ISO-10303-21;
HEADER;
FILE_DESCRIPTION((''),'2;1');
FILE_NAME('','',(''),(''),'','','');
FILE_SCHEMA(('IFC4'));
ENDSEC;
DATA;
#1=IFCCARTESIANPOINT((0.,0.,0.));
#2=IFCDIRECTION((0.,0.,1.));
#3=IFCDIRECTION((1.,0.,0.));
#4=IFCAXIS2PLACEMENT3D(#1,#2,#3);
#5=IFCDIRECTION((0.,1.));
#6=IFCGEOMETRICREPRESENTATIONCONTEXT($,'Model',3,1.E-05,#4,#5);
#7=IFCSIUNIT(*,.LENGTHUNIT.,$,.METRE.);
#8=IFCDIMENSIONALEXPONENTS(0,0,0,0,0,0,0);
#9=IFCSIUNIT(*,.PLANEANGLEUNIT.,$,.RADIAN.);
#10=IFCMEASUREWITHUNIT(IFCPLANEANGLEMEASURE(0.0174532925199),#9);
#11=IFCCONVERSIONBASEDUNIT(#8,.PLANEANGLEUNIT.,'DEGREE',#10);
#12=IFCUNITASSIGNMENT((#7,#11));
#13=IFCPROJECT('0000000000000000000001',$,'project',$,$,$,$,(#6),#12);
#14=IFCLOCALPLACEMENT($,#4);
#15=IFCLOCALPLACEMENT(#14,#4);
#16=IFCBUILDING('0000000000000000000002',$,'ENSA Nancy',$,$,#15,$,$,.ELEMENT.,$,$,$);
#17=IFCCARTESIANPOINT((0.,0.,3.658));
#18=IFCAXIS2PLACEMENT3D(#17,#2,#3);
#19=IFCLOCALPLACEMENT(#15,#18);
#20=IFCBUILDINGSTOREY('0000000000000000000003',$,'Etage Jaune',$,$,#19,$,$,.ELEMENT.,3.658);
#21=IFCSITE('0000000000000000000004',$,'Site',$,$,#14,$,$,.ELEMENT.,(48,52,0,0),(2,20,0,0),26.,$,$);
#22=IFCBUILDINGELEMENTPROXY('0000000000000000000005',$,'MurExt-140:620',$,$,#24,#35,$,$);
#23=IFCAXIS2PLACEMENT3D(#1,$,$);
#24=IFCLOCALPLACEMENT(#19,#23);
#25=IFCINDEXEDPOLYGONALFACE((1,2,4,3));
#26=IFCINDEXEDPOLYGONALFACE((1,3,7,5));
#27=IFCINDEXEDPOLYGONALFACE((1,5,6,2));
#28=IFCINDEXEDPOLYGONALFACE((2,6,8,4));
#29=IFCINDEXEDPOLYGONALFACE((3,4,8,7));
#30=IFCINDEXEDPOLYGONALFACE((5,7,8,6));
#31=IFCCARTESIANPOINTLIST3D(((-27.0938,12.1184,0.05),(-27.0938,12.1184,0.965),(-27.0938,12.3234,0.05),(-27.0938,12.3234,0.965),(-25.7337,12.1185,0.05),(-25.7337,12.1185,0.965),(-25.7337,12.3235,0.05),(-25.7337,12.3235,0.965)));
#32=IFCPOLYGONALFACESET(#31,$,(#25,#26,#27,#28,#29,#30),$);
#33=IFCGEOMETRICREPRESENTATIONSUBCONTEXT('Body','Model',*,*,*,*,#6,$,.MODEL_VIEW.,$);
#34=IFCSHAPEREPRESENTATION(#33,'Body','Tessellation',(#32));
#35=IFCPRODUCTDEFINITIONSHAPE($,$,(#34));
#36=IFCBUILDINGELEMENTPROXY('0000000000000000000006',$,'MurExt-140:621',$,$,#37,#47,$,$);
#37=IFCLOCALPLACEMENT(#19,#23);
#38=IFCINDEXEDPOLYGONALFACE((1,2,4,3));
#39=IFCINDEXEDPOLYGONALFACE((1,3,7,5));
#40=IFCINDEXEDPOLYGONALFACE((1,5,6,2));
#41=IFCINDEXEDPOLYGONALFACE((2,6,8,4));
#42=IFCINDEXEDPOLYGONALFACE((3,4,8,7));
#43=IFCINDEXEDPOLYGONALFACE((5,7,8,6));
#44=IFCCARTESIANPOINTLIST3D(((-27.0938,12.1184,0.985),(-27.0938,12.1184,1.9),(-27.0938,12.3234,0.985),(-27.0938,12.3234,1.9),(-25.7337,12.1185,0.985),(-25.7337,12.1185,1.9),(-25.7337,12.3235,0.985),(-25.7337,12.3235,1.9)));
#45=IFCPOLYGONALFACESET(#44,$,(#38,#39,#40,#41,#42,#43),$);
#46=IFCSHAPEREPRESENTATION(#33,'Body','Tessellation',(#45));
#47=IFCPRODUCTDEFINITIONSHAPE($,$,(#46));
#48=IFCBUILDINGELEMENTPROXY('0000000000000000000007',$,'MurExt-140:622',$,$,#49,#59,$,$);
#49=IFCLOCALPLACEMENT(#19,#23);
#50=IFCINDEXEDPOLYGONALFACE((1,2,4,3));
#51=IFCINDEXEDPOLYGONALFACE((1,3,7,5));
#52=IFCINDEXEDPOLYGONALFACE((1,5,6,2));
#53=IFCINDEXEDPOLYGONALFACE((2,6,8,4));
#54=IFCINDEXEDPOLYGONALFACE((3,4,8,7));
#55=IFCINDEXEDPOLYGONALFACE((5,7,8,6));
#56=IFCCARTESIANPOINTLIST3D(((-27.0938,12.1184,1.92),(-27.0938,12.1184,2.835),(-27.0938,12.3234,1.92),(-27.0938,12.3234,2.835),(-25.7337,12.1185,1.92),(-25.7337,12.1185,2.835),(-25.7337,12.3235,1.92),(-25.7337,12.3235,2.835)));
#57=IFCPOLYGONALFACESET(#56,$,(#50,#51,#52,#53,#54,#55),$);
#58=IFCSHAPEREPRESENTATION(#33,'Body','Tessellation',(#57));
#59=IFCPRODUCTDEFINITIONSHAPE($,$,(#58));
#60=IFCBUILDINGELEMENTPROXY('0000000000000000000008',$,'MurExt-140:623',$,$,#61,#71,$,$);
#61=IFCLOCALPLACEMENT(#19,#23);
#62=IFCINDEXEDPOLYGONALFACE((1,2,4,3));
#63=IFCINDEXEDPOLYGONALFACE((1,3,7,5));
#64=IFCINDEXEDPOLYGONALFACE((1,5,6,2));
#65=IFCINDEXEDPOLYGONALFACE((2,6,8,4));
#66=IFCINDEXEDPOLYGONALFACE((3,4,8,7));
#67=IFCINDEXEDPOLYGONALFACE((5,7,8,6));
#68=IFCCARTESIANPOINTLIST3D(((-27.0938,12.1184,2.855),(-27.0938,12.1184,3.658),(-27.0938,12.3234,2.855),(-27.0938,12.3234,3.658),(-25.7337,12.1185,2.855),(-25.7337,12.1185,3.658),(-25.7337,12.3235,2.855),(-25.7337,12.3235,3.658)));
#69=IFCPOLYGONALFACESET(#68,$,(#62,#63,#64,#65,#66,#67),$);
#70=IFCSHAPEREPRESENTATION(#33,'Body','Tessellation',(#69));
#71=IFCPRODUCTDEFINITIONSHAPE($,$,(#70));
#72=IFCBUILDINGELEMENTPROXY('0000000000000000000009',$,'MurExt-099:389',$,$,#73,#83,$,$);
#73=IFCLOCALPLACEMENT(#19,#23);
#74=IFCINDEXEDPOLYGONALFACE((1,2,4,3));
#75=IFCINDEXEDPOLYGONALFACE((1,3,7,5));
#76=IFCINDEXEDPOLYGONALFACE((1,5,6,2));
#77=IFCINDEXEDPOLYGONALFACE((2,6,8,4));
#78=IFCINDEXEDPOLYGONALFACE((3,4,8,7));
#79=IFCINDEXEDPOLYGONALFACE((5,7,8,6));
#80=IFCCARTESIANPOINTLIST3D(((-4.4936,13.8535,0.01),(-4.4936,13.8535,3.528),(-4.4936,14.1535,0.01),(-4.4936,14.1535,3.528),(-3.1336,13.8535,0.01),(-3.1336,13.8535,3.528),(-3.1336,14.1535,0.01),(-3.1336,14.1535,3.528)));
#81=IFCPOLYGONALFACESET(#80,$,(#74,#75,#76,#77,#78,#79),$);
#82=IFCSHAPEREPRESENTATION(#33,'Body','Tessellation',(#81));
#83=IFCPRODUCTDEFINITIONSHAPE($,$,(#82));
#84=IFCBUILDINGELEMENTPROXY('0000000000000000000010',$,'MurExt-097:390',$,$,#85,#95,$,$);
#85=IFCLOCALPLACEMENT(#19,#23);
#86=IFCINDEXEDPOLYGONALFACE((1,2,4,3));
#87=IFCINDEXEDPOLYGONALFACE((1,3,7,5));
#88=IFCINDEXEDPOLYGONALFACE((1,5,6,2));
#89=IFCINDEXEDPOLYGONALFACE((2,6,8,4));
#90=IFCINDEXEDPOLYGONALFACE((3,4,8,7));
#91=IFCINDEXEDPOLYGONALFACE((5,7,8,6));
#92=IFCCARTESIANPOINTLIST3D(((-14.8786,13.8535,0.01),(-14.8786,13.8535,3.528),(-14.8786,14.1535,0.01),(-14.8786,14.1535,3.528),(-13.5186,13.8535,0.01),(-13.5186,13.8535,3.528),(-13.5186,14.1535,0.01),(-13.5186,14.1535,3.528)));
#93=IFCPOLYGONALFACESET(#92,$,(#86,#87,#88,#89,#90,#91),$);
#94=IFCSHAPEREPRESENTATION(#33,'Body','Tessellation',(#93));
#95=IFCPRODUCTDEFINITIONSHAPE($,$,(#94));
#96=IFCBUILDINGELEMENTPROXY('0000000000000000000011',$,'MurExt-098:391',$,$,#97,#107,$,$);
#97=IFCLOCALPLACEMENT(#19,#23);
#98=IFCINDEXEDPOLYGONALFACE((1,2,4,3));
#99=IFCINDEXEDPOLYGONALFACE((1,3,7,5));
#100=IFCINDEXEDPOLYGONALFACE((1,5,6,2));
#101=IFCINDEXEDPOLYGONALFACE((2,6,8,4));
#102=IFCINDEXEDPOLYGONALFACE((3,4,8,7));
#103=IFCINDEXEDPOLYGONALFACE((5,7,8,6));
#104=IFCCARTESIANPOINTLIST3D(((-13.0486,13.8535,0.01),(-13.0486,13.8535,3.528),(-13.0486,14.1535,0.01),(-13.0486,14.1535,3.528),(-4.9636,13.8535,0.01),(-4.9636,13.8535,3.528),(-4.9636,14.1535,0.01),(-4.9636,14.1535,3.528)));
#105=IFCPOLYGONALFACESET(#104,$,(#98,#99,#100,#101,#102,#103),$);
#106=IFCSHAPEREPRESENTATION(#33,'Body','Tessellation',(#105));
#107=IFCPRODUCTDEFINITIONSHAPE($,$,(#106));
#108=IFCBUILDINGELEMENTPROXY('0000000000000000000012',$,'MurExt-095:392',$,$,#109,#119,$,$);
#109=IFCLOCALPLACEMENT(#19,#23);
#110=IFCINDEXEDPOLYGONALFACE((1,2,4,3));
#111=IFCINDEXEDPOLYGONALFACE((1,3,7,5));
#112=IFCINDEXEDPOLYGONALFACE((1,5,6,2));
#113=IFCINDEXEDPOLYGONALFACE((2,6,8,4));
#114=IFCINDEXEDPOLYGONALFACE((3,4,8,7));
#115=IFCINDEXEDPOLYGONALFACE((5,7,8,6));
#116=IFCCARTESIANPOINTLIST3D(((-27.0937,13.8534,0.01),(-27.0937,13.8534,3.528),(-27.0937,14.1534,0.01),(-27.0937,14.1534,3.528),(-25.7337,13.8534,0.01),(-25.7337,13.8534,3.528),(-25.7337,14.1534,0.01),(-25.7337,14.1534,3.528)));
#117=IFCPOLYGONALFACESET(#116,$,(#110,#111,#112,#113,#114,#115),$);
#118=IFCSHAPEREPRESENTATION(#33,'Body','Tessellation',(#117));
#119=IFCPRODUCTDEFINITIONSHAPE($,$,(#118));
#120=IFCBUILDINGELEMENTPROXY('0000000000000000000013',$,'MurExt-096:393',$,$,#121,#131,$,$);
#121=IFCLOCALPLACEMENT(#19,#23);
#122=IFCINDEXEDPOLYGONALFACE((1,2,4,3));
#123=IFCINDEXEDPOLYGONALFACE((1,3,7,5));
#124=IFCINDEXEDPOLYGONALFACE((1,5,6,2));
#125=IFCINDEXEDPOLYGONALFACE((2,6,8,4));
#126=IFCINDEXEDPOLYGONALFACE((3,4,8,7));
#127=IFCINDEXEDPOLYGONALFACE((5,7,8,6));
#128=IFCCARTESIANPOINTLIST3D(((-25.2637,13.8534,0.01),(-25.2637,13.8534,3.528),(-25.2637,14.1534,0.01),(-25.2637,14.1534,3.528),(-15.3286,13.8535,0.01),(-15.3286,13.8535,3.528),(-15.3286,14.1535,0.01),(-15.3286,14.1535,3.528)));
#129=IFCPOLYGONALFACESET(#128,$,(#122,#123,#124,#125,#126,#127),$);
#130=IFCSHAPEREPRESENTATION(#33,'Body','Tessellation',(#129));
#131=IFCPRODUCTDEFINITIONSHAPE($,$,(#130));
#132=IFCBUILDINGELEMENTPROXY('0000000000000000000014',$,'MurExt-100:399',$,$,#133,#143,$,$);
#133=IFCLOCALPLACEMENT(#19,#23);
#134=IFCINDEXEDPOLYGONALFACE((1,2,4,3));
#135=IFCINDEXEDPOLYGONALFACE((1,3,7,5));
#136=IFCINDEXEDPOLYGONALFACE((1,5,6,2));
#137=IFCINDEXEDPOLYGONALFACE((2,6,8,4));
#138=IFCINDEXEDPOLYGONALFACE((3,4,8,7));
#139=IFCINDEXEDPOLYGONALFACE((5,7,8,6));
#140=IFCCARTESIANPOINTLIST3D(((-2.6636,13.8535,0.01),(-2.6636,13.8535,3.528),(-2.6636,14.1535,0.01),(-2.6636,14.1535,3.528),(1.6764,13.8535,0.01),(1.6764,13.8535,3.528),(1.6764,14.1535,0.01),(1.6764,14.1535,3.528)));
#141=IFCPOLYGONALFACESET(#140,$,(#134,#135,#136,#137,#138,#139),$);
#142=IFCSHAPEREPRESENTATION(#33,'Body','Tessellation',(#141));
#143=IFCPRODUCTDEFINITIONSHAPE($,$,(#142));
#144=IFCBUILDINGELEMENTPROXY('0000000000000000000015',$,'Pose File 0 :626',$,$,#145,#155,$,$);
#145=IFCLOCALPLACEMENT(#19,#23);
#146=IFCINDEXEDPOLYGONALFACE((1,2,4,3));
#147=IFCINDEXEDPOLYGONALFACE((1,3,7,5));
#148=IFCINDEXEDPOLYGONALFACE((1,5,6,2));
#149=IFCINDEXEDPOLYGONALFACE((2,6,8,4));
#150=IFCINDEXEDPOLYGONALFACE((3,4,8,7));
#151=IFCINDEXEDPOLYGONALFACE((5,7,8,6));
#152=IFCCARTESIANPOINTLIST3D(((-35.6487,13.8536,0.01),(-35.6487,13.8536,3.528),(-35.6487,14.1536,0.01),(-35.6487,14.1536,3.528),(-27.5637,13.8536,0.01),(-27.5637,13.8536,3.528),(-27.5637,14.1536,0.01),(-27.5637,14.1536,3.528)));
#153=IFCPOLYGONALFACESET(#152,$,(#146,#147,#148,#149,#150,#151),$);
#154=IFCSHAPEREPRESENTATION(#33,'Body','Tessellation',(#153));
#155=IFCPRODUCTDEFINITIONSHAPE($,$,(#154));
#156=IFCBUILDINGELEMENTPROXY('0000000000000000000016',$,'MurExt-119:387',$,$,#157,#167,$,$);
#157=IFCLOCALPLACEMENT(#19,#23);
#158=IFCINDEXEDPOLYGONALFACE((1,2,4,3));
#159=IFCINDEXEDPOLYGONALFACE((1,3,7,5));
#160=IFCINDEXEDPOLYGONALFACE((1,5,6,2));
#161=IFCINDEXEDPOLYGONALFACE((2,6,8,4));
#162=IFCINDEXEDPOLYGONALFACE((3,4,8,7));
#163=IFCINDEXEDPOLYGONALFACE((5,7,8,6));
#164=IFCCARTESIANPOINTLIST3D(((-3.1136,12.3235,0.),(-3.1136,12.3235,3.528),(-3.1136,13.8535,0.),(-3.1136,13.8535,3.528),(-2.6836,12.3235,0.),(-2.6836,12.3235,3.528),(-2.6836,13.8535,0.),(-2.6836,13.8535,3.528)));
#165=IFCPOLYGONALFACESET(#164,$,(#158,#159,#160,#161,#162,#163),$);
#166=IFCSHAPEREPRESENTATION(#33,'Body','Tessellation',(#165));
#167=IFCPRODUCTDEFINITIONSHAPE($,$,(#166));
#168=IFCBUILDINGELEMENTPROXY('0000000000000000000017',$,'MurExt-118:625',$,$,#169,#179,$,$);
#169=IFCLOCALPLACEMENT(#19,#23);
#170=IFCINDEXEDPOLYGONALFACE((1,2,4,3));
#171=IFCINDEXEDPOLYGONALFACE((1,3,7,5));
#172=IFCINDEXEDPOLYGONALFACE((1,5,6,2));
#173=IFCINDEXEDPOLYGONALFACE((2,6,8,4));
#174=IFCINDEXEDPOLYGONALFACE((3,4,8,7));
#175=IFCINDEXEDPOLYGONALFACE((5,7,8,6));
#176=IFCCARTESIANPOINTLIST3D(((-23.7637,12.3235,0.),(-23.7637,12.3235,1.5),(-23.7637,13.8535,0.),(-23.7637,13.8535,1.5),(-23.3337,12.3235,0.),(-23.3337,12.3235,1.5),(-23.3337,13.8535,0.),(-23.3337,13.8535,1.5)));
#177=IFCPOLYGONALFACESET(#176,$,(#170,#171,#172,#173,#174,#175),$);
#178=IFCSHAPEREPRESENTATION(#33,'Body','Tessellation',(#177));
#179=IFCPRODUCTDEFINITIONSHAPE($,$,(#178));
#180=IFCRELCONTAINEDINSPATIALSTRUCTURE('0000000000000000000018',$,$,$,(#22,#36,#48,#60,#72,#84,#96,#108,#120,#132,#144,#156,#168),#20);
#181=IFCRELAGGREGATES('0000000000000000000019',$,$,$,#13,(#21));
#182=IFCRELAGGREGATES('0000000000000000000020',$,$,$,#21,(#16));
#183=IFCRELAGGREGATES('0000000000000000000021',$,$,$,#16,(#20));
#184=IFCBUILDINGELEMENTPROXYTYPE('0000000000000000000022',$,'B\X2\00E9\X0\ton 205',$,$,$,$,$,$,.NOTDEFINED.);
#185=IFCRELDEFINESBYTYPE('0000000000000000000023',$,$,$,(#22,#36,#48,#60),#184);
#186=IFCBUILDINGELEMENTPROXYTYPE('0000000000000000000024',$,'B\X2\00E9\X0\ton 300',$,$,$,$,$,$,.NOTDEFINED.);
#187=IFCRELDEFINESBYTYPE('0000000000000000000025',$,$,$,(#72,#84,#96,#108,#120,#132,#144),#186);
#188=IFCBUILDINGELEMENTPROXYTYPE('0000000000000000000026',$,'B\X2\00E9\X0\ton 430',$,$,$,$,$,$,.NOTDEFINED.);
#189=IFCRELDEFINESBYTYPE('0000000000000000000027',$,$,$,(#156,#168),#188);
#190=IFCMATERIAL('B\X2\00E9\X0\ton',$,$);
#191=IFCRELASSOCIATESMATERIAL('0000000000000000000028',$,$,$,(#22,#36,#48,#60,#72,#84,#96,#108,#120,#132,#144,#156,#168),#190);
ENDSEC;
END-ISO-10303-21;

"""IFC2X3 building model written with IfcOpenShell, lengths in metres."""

from ifc_helpers import new_model, entity, si_unit, converted_unit, direction, frame, origin_with_axes, place, context, subcontext, project, spatial, polyline, outline, extrude, material, type_object, element, save


model = new_model("IFC2X3")

# Units and contexts
model_context = context("Model", 3, precision=1e-05, world=origin_with_axes(), true_north=direction((0.0, 1.0)))
body_context = subcontext(model_context, "Body", "Model", "MODEL_VIEW")
ifc_project = project(units=[si_unit("LENGTHUNIT", "METRE"), converted_unit("PLANEANGLEUNIT", "DEGREE", entity("IfcPlaneAngleMeasure", 0.0174532925199), si_unit("PLANEANGLEUNIT", "RADIAN"), dimensions=[0, 0, 0, 0, 0, 0, 0])], contexts=[model_context])

# Site, building, storey
site_placement = place(None, origin_with_axes())
site = spatial("IfcSite", under=ifc_project, at=site_placement, Name="Site", CompositionType="ELEMENT", RefLatitude=(48, 52, 0, 0), RefLongitude=(2, 20, 0, 0), RefElevation=26.0)
building_placement = place(site_placement, origin_with_axes())
building = spatial("IfcBuilding", under=site, at=building_placement, Name="ENSA Nancy", CompositionType="ELEMENT")
storey_placement = place(building_placement, frame((0.0, 0.0, 3.658), z_axis=(0.0, 0.0, 1.0), x_axis=(1.0, 0.0, 0.0)))
storey = spatial("IfcBuildingStorey", under=building, at=storey_placement, Name="Etage Jaune", CompositionType="ELEMENT", Elevation=3.658)

# Building element proxies
ifc_material = material(Name="Béton")
building_element_proxy_type_1 = type_object("IfcBuildingElementProxyType", Name="Béton 205", PredefinedType="NOTDEFINED")
for number, where, z_axis, x_axis, name in (
    (1, (-27.0938, 12.3234, 0.05), (0.0, 0.0, 1.0), (1.0, 0.000034, 0.0), "MurExt-140:620"),
    (2, (-27.0938, 12.3234, 0.985), (0.0, 0.0, 1.0), (1.0, 0.000034, 0.0), "MurExt-140:621"),
    (3, (-27.0938, 12.3234, 1.92), (0.0, 0.0, 1.0), (1.0, 0.000034, 0.0), "MurExt-140:622"),
):
    element("IfcBuildingElementProxy", number, at=place(storey_placement, frame(where, z_axis=z_axis, x_axis=x_axis)), inside=storey, type_object=building_element_proxy_type_1, material=ifc_material, Name=name, context=body_context, shape_type="SweptSolid", body=[
        extrude(outline(polyline([(0.0, -0.205), (1.3601, -0.205), (1.3601, 0.0), (0.0, 0.0), (0.0, -0.205)])), origin_with_axes(), (0.0, 0.0, 1.0), 0.915),
    ])
proxy_1_placement = place(storey_placement, frame((-27.0938, 12.3234, 2.855), z_axis=(0.0, 0.0, 1.0), x_axis=(1.0, 0.000034, 0.0)))
element("IfcBuildingElementProxy", 4, at=proxy_1_placement, inside=storey, type_object=building_element_proxy_type_1, material=ifc_material, Name="MurExt-140:623", context=body_context, shape_type="SweptSolid", body=[
    extrude(outline(polyline([(0.0, -0.205), (1.3601, -0.205), (1.3601, 0.0), (0.0, 0.0), (0.0, -0.205)])), origin_with_axes(), (0.0, 0.0, 1.0), 0.803),
])
building_element_proxy_type_2 = type_object("IfcBuildingElementProxyType", Name="Béton 300", PredefinedType="NOTDEFINED")
proxy_2_placement = place(storey_placement, frame((-4.4936, 13.8535, 0.01), z_axis=(0.0, 0.0, 1.0), x_axis=(1.0, 0.0, 0.0)))
element("IfcBuildingElementProxy", 5, at=proxy_2_placement, inside=storey, type_object=building_element_proxy_type_2, material=ifc_material, Name="MurExt-099:389", context=body_context, shape_type="SweptSolid", body=[
    extrude(outline(polyline([(0.0, 0.0), (1.36, 0.0), (1.36, 0.3), (0.0, 0.3), (0.0, 0.0)])), origin_with_axes(), (0.0, 0.0, 1.0), 3.518),
])
proxy_3_placement = place(storey_placement, frame((-14.8786, 13.8535, 0.01), z_axis=(0.0, 0.0, 1.0), x_axis=(1.0, 0.0, 0.0)))
element("IfcBuildingElementProxy", 6, at=proxy_3_placement, inside=storey, type_object=building_element_proxy_type_2, material=ifc_material, Name="MurExt-097:390", context=body_context, shape_type="SweptSolid", body=[
    extrude(outline(polyline([(0.0, 0.0), (1.36, 0.0), (1.36, 0.3), (0.0, 0.3), (0.0, 0.0)])), origin_with_axes(), (0.0, 0.0, 1.0), 3.518),
])
proxy_4_placement = place(storey_placement, frame((-13.0486, 13.8535, 0.01), z_axis=(0.0, 0.0, 1.0), x_axis=(1.0, 0.0, 0.0)))
element("IfcBuildingElementProxy", 7, at=proxy_4_placement, inside=storey, type_object=building_element_proxy_type_2, material=ifc_material, Name="MurExt-098:391", context=body_context, shape_type="SweptSolid", body=[
    extrude(outline(polyline([(0.0, 0.0), (8.085, 0.0), (8.085, 0.3), (0.0, 0.3), (0.0, 0.0)])), origin_with_axes(), (0.0, 0.0, 1.0), 3.518),
])
proxy_5_placement = place(storey_placement, frame((-27.0937, 13.8534, 0.01), z_axis=(0.0, 0.0, 1.0), x_axis=(1.0, 0.0, 0.0)))
element("IfcBuildingElementProxy", 8, at=proxy_5_placement, inside=storey, type_object=building_element_proxy_type_2, material=ifc_material, Name="MurExt-095:392", context=body_context, shape_type="SweptSolid", body=[
    extrude(outline(polyline([(0.0, 0.0), (1.36, 0.0), (1.36, 0.3), (0.0, 0.3), (0.0, 0.0)])), origin_with_axes(), (0.0, 0.0, 1.0), 3.518),
])
proxy_6_placement = place(storey_placement, frame((-25.2637, 13.8534, 0.01), z_axis=(0.0, 0.0, 1.0), x_axis=(1.0, 0.000009, 0.0)))
element("IfcBuildingElementProxy", 9, at=proxy_6_placement, inside=storey, type_object=building_element_proxy_type_2, material=ifc_material, Name="MurExt-096:393", context=body_context, shape_type="SweptSolid", body=[
    extrude(outline(polyline([(0.0, 0.0), (9.9351, 0.0), (9.9351, 0.3), (0.0, 0.3), (0.0, 0.0)])), origin_with_axes(), (0.0, 0.0, 1.0), 3.518),
])
proxy_7_placement = place(storey_placement, frame((-2.6636, 13.8535, 0.01), z_axis=(0.0, 0.0, 1.0), x_axis=(1.0, 0.0, 0.0)))
element("IfcBuildingElementProxy", 10, at=proxy_7_placement, inside=storey, type_object=building_element_proxy_type_2, material=ifc_material, Name="MurExt-100:399", context=body_context, shape_type="SweptSolid", body=[
    extrude(outline(polyline([(0.0, 0.0), (4.34, 0.0), (4.34, 0.3), (0.0, 0.3), (0.0, 0.0)])), origin_with_axes(), (0.0, 0.0, 1.0), 3.518),
])
proxy_8_placement = place(storey_placement, frame((-27.5637, 13.8536, 0.01), z_axis=(0.0, 0.0, 1.0), x_axis=(-1.0, 0.0, 0.0)))
element("IfcBuildingElementProxy", 11, at=proxy_8_placement, inside=storey, type_object=building_element_proxy_type_2, material=ifc_material, Name="Pose File 0 :626", context=body_context, shape_type="SweptSolid", body=[
    extrude(outline(polyline([(0.0, -0.3), (8.085, -0.3), (8.085, 0.0), (0.0, 0.0), (0.0, -0.3)])), origin_with_axes(), (0.0, 0.0, 1.0), 3.518),
])
building_element_proxy_type_3 = type_object("IfcBuildingElementProxyType", Name="Béton 430", PredefinedType="NOTDEFINED")
proxy_9_placement = place(storey_placement, frame((-3.1136, 13.8535, 0.0), z_axis=(0.0, 0.0, 1.0), x_axis=(0.0, -1.0, 0.0)))
element("IfcBuildingElementProxy", 12, at=proxy_9_placement, inside=storey, type_object=building_element_proxy_type_3, material=ifc_material, Name="MurExt-119:387", context=body_context, shape_type="SweptSolid", body=[
    extrude(outline(polyline([(0.0, 0.0), (1.53, 0.0), (1.53, 0.43), (0.0, 0.43), (0.0, 0.0)])), origin_with_axes(), (0.0, 0.0, 1.0), 3.528),
])
proxy_10_placement = place(storey_placement, frame((-23.7637, 13.8535, 0.0), z_axis=(0.0, 0.0, 1.0), x_axis=(0.0, -1.0, 0.0)))
element("IfcBuildingElementProxy", 13, at=proxy_10_placement, inside=storey, type_object=building_element_proxy_type_3, material=ifc_material, Name="MurExt-118:625", context=body_context, shape_type="SweptSolid", body=[
    extrude(outline(polyline([(0.0, 0.0), (1.53, 0.0), (1.53, 0.43), (0.0, 0.43), (0.0, 0.0)])), origin_with_axes(), (0.0, 0.0, 1.0), 1.5),
])

save(model, "model.ifc")
